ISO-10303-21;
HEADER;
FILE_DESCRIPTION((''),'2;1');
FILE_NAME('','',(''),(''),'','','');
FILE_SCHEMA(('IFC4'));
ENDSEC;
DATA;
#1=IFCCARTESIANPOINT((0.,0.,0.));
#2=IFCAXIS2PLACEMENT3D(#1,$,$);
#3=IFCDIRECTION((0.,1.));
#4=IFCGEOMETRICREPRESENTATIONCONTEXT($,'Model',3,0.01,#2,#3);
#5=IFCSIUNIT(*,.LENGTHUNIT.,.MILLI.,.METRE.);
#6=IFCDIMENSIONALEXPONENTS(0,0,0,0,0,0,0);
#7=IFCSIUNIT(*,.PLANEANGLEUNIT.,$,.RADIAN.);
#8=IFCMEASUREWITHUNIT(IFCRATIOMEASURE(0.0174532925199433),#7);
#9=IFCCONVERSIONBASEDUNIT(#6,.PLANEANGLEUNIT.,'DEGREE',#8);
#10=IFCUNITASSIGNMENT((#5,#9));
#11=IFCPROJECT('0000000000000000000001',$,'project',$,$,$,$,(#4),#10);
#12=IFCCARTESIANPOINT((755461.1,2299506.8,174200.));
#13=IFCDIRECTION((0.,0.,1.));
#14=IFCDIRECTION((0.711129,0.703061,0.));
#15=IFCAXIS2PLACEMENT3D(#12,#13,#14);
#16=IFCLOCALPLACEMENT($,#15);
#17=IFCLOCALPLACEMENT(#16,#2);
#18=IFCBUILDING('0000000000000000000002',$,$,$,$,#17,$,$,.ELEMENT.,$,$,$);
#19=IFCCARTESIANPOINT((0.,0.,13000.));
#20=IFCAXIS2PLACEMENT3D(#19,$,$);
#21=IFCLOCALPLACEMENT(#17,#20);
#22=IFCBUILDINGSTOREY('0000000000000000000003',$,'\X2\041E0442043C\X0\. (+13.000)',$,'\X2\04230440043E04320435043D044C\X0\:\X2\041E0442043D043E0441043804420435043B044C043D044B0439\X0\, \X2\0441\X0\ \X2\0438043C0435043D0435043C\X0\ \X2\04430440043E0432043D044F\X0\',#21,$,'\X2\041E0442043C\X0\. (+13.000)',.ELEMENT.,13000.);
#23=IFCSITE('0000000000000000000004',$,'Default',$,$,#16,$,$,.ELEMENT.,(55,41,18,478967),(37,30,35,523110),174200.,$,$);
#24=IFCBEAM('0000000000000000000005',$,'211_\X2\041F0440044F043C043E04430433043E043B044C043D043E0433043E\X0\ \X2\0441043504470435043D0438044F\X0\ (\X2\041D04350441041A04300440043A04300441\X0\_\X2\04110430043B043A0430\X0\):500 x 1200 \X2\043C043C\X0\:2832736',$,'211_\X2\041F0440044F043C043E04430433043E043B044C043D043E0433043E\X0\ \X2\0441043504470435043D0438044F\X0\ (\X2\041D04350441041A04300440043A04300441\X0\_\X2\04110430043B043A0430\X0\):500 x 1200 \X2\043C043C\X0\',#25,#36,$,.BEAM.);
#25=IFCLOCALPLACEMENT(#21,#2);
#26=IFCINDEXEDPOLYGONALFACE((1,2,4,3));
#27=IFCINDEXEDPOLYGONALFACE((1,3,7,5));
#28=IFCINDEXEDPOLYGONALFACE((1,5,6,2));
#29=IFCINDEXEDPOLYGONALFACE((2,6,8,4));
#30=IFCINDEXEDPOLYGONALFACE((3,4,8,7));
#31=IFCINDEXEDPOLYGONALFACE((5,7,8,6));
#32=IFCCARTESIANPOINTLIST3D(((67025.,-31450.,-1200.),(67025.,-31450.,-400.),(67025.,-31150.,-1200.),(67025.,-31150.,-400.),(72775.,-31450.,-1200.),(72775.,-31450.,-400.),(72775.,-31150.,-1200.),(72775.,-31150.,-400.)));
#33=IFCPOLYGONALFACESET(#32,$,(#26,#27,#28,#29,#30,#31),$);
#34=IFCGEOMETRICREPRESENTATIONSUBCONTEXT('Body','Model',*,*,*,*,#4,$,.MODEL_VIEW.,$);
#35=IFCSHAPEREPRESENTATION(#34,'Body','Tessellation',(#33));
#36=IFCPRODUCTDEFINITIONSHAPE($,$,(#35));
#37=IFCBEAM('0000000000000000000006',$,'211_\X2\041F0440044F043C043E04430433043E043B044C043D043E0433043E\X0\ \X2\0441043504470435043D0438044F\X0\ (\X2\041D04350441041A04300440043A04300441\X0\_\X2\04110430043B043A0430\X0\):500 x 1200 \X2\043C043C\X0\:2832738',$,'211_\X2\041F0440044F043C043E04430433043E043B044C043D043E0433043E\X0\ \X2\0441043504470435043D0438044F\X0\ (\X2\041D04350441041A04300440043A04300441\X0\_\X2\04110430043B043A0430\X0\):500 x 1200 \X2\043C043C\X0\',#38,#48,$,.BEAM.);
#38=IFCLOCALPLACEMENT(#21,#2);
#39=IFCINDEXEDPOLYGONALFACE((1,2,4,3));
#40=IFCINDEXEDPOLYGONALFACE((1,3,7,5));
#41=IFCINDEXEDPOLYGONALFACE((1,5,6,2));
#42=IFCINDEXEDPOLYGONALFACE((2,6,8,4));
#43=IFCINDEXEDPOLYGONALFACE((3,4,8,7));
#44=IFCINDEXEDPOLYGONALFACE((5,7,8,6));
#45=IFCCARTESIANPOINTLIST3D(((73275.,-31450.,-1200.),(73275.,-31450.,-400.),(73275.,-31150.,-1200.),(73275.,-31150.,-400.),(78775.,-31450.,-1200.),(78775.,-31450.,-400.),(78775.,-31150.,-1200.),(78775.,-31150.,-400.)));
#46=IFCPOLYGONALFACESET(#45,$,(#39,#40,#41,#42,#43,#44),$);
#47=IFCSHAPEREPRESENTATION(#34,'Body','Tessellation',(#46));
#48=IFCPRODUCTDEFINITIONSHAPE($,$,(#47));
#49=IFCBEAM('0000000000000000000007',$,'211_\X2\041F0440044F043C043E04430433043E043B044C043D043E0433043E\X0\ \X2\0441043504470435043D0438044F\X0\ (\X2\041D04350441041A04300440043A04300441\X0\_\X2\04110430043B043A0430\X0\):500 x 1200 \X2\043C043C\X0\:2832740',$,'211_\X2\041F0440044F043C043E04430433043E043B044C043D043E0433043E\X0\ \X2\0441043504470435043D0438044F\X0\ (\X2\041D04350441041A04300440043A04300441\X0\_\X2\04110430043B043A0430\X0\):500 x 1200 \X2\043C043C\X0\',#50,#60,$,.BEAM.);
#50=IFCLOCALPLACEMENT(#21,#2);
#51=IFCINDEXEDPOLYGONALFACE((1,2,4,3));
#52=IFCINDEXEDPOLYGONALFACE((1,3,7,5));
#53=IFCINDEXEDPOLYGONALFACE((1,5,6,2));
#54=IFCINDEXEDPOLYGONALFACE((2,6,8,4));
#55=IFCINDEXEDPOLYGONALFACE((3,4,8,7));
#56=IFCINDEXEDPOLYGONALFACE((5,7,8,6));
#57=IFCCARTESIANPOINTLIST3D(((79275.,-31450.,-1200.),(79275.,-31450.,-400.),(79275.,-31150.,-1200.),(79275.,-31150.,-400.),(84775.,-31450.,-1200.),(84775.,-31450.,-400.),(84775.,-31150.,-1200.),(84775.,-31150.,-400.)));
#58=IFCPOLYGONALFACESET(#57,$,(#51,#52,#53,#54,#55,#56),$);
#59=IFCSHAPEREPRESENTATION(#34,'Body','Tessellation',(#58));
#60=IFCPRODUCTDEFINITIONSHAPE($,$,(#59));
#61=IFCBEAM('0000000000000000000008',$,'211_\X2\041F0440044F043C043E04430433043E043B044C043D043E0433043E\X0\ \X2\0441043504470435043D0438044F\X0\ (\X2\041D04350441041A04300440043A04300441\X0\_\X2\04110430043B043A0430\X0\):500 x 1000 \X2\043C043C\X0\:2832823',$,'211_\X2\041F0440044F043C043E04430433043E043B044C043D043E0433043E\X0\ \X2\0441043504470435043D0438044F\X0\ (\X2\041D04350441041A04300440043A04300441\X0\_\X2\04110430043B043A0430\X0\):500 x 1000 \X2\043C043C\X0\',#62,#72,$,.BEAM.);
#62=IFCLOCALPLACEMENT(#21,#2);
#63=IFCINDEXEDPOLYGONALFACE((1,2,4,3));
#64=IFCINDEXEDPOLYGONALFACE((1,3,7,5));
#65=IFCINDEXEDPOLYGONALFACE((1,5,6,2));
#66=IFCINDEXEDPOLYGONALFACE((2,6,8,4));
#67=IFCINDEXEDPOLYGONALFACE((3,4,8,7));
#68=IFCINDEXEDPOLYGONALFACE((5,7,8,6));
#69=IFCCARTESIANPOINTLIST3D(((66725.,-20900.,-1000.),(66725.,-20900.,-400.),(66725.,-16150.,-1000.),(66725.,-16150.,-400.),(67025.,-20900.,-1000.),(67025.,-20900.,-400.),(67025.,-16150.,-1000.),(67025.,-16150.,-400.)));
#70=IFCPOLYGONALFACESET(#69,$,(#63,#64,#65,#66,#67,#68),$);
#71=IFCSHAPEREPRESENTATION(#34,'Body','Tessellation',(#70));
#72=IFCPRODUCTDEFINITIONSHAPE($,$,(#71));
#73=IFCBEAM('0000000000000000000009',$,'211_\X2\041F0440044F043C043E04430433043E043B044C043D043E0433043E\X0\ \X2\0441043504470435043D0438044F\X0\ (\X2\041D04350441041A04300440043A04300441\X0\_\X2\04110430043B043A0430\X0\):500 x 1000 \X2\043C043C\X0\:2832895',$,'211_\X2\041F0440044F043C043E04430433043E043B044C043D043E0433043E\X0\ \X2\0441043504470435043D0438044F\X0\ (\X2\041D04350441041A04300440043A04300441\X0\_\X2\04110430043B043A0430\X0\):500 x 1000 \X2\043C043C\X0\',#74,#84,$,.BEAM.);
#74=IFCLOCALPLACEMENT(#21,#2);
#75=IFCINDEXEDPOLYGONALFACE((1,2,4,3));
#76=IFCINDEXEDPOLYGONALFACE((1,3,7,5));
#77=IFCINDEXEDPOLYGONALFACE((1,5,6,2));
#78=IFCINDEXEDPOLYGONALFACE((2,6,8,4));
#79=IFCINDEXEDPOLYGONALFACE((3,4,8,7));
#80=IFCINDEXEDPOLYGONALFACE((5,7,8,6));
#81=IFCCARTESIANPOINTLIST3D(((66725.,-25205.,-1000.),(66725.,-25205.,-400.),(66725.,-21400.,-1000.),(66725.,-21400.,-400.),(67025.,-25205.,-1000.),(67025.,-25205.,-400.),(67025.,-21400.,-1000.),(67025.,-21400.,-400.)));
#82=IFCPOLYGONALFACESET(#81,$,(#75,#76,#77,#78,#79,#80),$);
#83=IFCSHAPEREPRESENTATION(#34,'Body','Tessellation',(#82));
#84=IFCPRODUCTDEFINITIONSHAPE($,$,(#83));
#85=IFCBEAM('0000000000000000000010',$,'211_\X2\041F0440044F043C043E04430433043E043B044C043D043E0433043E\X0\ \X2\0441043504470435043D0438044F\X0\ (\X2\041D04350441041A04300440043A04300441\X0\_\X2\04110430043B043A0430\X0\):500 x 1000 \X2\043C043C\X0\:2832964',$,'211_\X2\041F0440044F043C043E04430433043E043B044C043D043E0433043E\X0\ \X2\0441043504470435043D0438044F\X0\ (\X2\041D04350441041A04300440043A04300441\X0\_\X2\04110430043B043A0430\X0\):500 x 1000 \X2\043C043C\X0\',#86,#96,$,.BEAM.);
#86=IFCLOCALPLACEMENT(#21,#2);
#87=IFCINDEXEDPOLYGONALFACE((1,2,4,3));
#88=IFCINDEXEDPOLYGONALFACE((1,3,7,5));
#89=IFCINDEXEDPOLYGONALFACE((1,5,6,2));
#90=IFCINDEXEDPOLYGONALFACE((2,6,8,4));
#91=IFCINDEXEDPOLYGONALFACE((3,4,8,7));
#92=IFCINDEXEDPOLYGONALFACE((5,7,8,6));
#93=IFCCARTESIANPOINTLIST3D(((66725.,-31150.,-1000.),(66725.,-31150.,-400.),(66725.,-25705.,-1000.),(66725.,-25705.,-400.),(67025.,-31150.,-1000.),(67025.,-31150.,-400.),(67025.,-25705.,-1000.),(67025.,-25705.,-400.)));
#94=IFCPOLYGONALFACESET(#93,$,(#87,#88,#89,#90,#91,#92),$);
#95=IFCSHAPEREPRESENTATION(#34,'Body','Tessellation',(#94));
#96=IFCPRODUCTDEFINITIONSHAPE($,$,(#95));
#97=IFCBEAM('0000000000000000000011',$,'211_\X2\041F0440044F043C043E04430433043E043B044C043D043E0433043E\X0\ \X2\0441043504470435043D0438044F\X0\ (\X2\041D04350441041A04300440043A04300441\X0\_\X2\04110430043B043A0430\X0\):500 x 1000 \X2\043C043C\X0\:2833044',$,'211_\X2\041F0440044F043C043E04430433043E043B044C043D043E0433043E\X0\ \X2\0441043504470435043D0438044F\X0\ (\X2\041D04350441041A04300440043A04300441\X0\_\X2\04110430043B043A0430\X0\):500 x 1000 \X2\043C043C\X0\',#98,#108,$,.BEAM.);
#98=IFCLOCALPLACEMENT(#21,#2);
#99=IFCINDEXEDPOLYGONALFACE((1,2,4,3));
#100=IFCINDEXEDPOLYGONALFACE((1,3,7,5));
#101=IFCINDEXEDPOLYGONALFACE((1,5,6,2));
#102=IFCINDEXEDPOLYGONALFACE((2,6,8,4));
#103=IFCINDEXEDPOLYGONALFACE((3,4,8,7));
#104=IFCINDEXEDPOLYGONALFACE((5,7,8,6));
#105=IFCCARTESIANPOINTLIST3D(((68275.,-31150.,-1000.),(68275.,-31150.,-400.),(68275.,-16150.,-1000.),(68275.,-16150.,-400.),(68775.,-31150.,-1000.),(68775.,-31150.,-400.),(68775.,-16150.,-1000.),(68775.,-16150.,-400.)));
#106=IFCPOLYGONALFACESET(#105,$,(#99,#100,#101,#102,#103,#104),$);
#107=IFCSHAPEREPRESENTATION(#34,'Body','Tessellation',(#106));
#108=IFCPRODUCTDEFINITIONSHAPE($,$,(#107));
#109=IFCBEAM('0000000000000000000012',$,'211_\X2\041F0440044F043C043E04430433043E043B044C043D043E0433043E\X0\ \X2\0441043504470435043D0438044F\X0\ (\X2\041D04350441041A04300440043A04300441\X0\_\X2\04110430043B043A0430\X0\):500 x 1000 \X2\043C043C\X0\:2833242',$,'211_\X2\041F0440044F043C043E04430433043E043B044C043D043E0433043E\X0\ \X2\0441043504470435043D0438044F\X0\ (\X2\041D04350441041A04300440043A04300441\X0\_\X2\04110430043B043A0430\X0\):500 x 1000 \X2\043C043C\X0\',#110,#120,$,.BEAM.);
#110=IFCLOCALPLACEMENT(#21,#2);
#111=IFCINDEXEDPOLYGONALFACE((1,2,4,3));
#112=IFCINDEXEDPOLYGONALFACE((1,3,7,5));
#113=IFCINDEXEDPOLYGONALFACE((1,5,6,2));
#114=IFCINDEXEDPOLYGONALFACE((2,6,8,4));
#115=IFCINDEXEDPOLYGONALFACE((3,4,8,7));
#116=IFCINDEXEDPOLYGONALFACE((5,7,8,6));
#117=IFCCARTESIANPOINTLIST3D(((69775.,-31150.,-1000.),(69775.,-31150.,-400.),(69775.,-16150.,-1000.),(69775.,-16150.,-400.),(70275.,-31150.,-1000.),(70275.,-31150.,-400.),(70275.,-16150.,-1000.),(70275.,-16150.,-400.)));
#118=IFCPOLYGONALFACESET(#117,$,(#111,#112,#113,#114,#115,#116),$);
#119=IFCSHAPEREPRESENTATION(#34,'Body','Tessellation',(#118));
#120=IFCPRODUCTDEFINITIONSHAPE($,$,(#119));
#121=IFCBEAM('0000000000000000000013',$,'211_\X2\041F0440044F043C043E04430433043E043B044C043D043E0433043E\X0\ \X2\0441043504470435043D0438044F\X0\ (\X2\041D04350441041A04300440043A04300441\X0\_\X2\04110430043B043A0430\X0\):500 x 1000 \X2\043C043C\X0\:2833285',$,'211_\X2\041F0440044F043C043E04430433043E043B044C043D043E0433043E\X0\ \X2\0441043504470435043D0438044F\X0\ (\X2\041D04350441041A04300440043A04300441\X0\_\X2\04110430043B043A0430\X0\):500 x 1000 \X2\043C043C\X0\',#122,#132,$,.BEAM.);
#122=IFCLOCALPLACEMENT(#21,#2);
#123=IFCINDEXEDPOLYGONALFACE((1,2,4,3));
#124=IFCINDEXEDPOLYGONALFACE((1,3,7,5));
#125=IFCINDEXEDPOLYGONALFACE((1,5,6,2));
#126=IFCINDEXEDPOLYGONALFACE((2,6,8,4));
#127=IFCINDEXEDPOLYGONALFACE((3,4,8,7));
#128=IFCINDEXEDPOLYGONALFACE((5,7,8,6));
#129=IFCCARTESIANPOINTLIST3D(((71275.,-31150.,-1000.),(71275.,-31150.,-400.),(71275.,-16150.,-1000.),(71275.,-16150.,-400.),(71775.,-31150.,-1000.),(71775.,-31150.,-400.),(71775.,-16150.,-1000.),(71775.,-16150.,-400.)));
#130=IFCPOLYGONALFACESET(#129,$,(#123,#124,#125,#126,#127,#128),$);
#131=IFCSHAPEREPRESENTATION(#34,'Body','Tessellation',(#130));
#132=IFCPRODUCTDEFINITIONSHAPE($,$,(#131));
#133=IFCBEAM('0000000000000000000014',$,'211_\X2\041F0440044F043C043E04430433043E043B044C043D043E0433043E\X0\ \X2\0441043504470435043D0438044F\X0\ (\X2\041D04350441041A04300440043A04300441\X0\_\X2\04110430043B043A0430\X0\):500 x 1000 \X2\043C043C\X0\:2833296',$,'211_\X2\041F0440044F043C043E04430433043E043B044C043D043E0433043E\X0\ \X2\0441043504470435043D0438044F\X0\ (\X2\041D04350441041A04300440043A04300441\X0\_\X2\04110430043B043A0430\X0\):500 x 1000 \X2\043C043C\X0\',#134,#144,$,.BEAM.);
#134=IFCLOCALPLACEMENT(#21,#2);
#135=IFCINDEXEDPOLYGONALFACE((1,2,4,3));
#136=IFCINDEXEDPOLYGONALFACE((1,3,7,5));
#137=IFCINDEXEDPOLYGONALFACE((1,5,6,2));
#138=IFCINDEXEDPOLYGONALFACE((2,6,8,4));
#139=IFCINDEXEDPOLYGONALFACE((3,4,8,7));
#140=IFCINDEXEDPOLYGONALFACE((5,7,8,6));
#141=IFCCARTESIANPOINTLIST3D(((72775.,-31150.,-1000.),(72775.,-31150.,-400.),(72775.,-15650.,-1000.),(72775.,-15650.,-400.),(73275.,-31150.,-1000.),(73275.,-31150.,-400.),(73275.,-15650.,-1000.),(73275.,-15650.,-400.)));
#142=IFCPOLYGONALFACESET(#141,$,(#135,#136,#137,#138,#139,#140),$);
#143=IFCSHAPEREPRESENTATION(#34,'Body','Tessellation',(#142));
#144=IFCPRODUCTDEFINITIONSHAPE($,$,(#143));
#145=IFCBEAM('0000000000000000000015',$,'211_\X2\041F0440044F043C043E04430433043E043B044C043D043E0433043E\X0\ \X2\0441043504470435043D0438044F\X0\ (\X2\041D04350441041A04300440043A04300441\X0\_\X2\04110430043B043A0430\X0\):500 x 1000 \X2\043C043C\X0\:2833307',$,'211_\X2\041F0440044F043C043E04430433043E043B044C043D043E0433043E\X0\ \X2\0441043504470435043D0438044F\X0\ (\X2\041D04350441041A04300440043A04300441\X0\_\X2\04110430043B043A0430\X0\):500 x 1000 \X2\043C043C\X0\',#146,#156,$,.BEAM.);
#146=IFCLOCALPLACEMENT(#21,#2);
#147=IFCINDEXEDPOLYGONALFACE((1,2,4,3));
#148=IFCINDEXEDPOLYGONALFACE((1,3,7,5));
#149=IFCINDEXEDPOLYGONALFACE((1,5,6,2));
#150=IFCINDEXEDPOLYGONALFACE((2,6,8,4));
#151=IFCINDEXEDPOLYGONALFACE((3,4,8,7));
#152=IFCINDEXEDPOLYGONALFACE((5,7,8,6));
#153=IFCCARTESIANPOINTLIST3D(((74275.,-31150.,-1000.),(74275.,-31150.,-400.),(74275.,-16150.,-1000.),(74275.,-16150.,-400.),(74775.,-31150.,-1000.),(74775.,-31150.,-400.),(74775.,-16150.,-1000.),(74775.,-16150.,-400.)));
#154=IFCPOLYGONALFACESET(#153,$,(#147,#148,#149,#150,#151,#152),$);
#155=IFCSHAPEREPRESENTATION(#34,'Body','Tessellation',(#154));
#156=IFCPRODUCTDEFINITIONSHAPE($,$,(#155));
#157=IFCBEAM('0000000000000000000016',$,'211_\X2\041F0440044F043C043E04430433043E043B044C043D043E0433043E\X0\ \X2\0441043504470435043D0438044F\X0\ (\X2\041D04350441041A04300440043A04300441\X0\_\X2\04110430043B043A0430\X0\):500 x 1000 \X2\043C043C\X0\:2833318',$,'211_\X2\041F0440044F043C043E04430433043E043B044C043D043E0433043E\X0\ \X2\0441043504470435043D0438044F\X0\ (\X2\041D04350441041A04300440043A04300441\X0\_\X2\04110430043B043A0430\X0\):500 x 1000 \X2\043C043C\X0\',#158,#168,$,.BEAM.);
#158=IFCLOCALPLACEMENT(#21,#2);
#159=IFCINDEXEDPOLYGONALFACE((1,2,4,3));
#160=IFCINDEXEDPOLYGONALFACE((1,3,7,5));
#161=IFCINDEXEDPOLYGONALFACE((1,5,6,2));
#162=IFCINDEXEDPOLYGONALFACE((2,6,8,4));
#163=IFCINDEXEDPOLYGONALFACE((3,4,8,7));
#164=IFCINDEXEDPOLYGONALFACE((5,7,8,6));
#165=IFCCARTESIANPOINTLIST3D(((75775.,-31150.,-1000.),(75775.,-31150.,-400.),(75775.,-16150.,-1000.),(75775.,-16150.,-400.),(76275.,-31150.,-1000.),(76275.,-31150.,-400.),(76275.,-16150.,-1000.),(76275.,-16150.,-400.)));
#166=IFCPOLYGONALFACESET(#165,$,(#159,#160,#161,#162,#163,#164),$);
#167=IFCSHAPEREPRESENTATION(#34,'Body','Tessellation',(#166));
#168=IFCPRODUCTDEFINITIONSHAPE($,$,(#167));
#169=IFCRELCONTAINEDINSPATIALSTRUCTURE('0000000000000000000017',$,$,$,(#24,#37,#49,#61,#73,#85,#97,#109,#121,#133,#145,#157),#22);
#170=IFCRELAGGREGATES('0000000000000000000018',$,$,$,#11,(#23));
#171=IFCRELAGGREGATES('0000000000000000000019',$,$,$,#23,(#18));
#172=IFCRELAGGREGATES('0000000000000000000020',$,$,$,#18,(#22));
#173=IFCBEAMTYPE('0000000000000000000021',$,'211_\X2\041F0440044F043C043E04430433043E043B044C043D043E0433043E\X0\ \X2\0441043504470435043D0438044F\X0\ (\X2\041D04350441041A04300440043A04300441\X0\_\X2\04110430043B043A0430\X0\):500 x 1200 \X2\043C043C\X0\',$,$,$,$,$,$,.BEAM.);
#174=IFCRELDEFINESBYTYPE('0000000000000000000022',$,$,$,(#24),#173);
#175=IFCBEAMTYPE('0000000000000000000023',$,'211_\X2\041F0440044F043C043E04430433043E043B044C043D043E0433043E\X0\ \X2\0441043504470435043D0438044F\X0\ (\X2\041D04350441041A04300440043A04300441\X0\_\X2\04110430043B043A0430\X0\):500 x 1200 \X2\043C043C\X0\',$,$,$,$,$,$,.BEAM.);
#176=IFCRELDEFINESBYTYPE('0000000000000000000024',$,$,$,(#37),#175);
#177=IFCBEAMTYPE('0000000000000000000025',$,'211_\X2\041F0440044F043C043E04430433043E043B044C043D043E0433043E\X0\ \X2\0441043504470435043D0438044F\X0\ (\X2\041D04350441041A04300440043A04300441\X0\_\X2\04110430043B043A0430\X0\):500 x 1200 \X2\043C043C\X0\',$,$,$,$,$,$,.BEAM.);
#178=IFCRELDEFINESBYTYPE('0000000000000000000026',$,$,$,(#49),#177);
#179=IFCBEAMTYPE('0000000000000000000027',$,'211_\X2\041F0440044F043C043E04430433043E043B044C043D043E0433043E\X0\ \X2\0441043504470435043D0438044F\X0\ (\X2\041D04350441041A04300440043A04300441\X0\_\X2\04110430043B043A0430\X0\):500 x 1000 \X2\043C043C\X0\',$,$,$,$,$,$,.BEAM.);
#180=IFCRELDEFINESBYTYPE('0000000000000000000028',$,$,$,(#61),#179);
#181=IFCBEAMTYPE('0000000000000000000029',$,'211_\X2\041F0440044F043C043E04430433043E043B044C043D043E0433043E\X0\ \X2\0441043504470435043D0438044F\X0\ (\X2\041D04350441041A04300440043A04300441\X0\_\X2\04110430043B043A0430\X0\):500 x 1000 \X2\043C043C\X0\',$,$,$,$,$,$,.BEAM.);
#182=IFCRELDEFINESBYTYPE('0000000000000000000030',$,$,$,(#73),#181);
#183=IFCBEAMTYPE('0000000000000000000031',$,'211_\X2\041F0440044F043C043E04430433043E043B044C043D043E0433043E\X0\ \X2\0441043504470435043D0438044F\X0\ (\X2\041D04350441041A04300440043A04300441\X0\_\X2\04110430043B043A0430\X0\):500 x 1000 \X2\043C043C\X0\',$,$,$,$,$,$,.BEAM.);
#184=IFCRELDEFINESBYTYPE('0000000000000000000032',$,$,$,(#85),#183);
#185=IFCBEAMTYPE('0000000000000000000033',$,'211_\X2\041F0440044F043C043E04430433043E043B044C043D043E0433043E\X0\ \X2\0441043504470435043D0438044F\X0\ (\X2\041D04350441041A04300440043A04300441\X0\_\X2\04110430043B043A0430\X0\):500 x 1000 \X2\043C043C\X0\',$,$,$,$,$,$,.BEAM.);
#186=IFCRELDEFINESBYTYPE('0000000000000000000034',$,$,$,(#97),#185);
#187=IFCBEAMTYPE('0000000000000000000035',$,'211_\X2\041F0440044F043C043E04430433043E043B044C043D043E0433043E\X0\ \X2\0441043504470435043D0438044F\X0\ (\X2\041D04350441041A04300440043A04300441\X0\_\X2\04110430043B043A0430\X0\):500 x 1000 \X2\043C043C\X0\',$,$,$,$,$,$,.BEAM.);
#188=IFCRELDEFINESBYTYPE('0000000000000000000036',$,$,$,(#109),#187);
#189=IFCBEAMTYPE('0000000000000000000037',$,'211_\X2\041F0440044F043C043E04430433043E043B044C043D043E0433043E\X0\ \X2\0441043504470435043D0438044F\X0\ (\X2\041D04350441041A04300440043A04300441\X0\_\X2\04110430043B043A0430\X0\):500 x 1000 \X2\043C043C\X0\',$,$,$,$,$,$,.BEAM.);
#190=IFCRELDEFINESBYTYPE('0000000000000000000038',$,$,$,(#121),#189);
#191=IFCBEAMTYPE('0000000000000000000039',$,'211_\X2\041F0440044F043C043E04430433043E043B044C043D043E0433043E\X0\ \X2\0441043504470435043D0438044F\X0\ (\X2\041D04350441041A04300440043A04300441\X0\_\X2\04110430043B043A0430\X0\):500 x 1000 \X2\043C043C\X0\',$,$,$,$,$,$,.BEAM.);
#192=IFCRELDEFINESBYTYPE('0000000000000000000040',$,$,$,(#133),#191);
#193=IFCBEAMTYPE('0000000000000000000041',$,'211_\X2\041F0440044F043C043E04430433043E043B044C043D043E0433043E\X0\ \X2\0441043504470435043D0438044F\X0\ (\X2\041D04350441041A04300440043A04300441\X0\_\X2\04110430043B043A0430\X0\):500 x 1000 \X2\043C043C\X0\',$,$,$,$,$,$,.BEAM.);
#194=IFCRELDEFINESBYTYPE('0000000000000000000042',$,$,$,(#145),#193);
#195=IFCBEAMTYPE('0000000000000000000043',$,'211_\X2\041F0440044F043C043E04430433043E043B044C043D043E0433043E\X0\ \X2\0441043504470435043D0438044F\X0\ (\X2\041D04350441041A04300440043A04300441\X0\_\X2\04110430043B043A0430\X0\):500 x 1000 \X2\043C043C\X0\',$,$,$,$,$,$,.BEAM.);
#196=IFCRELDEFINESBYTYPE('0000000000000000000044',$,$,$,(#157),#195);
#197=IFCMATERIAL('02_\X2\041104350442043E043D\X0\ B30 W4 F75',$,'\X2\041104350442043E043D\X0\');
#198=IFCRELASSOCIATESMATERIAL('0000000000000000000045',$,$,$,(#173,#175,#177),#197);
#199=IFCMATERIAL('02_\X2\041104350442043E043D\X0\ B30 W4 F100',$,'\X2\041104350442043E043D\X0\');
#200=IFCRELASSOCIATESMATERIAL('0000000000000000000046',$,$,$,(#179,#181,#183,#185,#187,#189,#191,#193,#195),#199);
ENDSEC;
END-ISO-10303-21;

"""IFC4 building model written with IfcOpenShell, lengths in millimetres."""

from ifc_helpers import new_model, entity, si_unit, converted_unit, direction, frame, origin, place, context, subcontext, project, spatial, indexed_curve, outline, extrude, source, transform, mapped, material, type_object, type_shapes, element, save


model = new_model("IFC4")

# Units and contexts
model_context = context("Model", 3, precision=0.01, world=origin(), true_north=direction((0.0, 1.0)))
body_context = subcontext(model_context, "Body", "Model", "MODEL_VIEW")
ifc_project = project(units=[si_unit("LENGTHUNIT", "METRE", prefix="MILLI"), converted_unit("PLANEANGLEUNIT", "DEGREE", entity("IfcRatioMeasure", 0.0174532925199433), si_unit("PLANEANGLEUNIT", "RADIAN"), dimensions=[0, 0, 0, 0, 0, 0, 0])], contexts=[model_context])

# Site, building, storey
site_placement = place(None, frame((755461.1, 2299506.8, 174200.0), z_axis=(0.0, 0.0, 1.0), x_axis=(0.711129, 0.703061, 0.0)))
site = spatial("IfcSite", under=ifc_project, at=site_placement, Name="Default", CompositionType="ELEMENT", RefLatitude=(55, 41, 18, 478967), RefLongitude=(37, 30, 35, 523110), RefElevation=174200.0)
building_placement = place(site_placement, origin())
building = spatial("IfcBuilding", under=site, at=building_placement, CompositionType="ELEMENT")
storey_placement = place(building_placement, frame((0.0, 0.0, 13000.0)))
storey = spatial("IfcBuildingStorey", under=building, at=storey_placement, Name="Отм. (+13.000)", ObjectType="Уровень:Относительный, с именем уровня", LongName="Отм. (+13.000)", CompositionType="ELEMENT", Elevation=13000.0)

# Beams
ifc_material_1 = material(Name="02_Бетон B30 W4 F75", Category="Бетон")
beam_type_1 = type_object("IfcBeamType", Name="211_Прямоугольного сечения (НесКаркас_Балка):500 x 1200 мм", PredefinedType="BEAM", material=ifc_material_1)
shared_shape_1 = source(origin(), body_context, "Body", "SweptSolid", [
    extrude(outline(indexed_curve([(-400.0, -150.0), (400.0, -150.0), (400.0, 150.0), (-400.0, 150.0), (-400.0, -150.0)], self_intersect=False)), frame((67025.0, -31300.0, 12200.0), z_axis=(1.0, 0.0, 0.0), x_axis=(0.0, 0.0, -1.0)), (0.0, 0.0, 1.0), 5750.0),
])
type_shapes(beam_type_1, [shared_shape_1])
beam_1_placement = place(storey_placement, frame((0.0, 0.0, -13000.0)))
element("IfcBeam", 1, at=beam_1_placement, inside=storey, type_object=beam_type_1, Name="211_Прямоугольного сечения (НесКаркас_Балка):500 x 1200 мм:2832736", ObjectType="211_Прямоугольного сечения (НесКаркас_Балка):500 x 1200 мм", PredefinedType="BEAM", context=body_context, shape_type="MappedRepresentation", body=[
    mapped(shared_shape_1, transform((0.0, 0.0, 0.0), scale=1.0)),
])
beam_type_2 = type_object("IfcBeamType", Name="211_Прямоугольного сечения (НесКаркас_Балка):500 x 1200 мм", PredefinedType="BEAM", material=ifc_material_1)
shared_shape_2 = source(origin(), body_context, "Body", "SweptSolid", [
    extrude(outline(indexed_curve([(-400.0, -150.0), (400.0, -150.0), (400.0, 150.0), (-400.0, 150.0), (-400.0, -150.0)], self_intersect=False)), frame((73275.0, -31300.0, 12200.0), z_axis=(1.0, 0.0, 0.0), x_axis=(0.0, 0.0, -1.0)), (0.0, 0.0, 1.0), 5500.0),
])
type_shapes(beam_type_2, [shared_shape_2])
beam_2_placement = place(storey_placement, frame((0.0, 0.0, -13000.0)))
element("IfcBeam", 2, at=beam_2_placement, inside=storey, type_object=beam_type_2, Name="211_Прямоугольного сечения (НесКаркас_Балка):500 x 1200 мм:2832738", ObjectType="211_Прямоугольного сечения (НесКаркас_Балка):500 x 1200 мм", PredefinedType="BEAM", context=body_context, shape_type="MappedRepresentation", body=[
    mapped(shared_shape_2, transform((0.0, 0.0, 0.0), scale=1.0)),
])
beam_type_3 = type_object("IfcBeamType", Name="211_Прямоугольного сечения (НесКаркас_Балка):500 x 1200 мм", PredefinedType="BEAM", material=ifc_material_1)
shared_shape_3 = source(origin(), body_context, "Body", "SweptSolid", [
    extrude(outline(indexed_curve([(-400.0, -150.0), (400.0, -150.0), (400.0, 150.0), (-400.0, 150.0), (-400.0, -150.0)], self_intersect=False)), frame((79275.0, -31300.0, 12200.0), z_axis=(1.0, 0.0, 0.0), x_axis=(0.0, 0.0, -1.0)), (0.0, 0.0, 1.0), 5500.0),
])
type_shapes(beam_type_3, [shared_shape_3])
beam_3_placement = place(storey_placement, frame((0.0, 0.0, -13000.0)))
element("IfcBeam", 3, at=beam_3_placement, inside=storey, type_object=beam_type_3, Name="211_Прямоугольного сечения (НесКаркас_Балка):500 x 1200 мм:2832740", ObjectType="211_Прямоугольного сечения (НесКаркас_Балка):500 x 1200 мм", PredefinedType="BEAM", context=body_context, shape_type="MappedRepresentation", body=[
    mapped(shared_shape_3, transform((0.0, 0.0, 0.0), scale=1.0)),
])
ifc_material_2 = material(Name="02_Бетон B30 W4 F100", Category="Бетон")
beam_type_4 = type_object("IfcBeamType", Name="211_Прямоугольного сечения (НесКаркас_Балка):500 x 1000 мм", PredefinedType="BEAM", material=ifc_material_2)
shared_shape_4 = source(origin(), body_context, "Body", "SweptSolid", [
    extrude(outline(indexed_curve([(-150.0, -300.0), (150.0, -300.0), (150.0, 300.0), (-150.0, 300.0), (-150.0, -300.0)], self_intersect=False)), frame((66875.0, -16150.0, 12300.0), z_axis=(0.0, -1.0, 0.0), x_axis=(-1.0, 0.0, 0.0)), (0.0, 0.0, 1.0), 4750.0),
])
type_shapes(beam_type_4, [shared_shape_4])
beam_4_placement = place(storey_placement, frame((0.0, 0.0, -13000.0)))
element("IfcBeam", 4, at=beam_4_placement, inside=storey, type_object=beam_type_4, Name="211_Прямоугольного сечения (НесКаркас_Балка):500 x 1000 мм:2832823", ObjectType="211_Прямоугольного сечения (НесКаркас_Балка):500 x 1000 мм", PredefinedType="BEAM", context=body_context, shape_type="MappedRepresentation", body=[
    mapped(shared_shape_4, transform((0.0, 0.0, 0.0), scale=1.0)),
])
beam_type_5 = type_object("IfcBeamType", Name="211_Прямоугольного сечения (НесКаркас_Балка):500 x 1000 мм", PredefinedType="BEAM", material=ifc_material_2)
shared_shape_5 = source(origin(), body_context, "Body", "SweptSolid", [
    extrude(outline(indexed_curve([(-150.0, -300.0), (150.0, -300.0), (150.0, 300.0), (-150.0, 300.0), (-150.0, -300.0)], self_intersect=False)), frame((66875.0, -21400.0, 12300.0), z_axis=(0.0, -1.0, 0.0), x_axis=(-1.0, 0.0, 0.0)), (0.0, 0.0, 1.0), 3805.0),
])
type_shapes(beam_type_5, [shared_shape_5])
beam_5_placement = place(storey_placement, frame((0.0, 0.0, -13000.0)))
element("IfcBeam", 5, at=beam_5_placement, inside=storey, type_object=beam_type_5, Name="211_Прямоугольного сечения (НесКаркас_Балка):500 x 1000 мм:2832895", ObjectType="211_Прямоугольного сечения (НесКаркас_Балка):500 x 1000 мм", PredefinedType="BEAM", context=body_context, shape_type="MappedRepresentation", body=[
    mapped(shared_shape_5, transform((0.0, 0.0, 0.0), scale=1.0)),
])
beam_type_6 = type_object("IfcBeamType", Name="211_Прямоугольного сечения (НесКаркас_Балка):500 x 1000 мм", PredefinedType="BEAM", material=ifc_material_2)
shared_shape_6 = source(origin(), body_context, "Body", "SweptSolid", [
    extrude(outline(indexed_curve([(-150.0, -300.0), (150.0, -300.0), (150.0, 300.0), (-150.0, 300.0), (-150.0, -300.0)], self_intersect=False)), frame((66875.0, -25705.0, 12300.0), z_axis=(0.0, -1.0, 0.0), x_axis=(-1.0, 0.0, 0.0)), (0.0, 0.0, 1.0), 5445.0),
])
type_shapes(beam_type_6, [shared_shape_6])
beam_6_placement = place(storey_placement, frame((0.0, 0.0, -13000.0)))
element("IfcBeam", 6, at=beam_6_placement, inside=storey, type_object=beam_type_6, Name="211_Прямоугольного сечения (НесКаркас_Балка):500 x 1000 мм:2832964", ObjectType="211_Прямоугольного сечения (НесКаркас_Балка):500 x 1000 мм", PredefinedType="BEAM", context=body_context, shape_type="MappedRepresentation", body=[
    mapped(shared_shape_6, transform((0.0, 0.0, 0.0), scale=1.0)),
])
beam_type_7 = type_object("IfcBeamType", Name="211_Прямоугольного сечения (НесКаркас_Балка):500 x 1000 мм", PredefinedType="BEAM", material=ifc_material_2)
shared_shape_7 = source(origin(), body_context, "Body", "SweptSolid", [
    extrude(outline(indexed_curve([(-250.0, -300.0), (250.0, -300.0), (250.0, 300.0), (-250.0, 300.0), (-250.0, -300.0)], self_intersect=False)), frame((68525.0, -16150.0, 12300.0), z_axis=(0.0, -1.0, 0.0), x_axis=(-1.0, 0.0, 0.0)), (0.0, 0.0, 1.0), 15000.0),
])
type_shapes(beam_type_7, [shared_shape_7])
beam_7_placement = place(storey_placement, frame((0.0, 0.0, -13000.0)))
element("IfcBeam", 7, at=beam_7_placement, inside=storey, type_object=beam_type_7, Name="211_Прямоугольного сечения (НесКаркас_Балка):500 x 1000 мм:2833044", ObjectType="211_Прямоугольного сечения (НесКаркас_Балка):500 x 1000 мм", PredefinedType="BEAM", context=body_context, shape_type="MappedRepresentation", body=[
    mapped(shared_shape_7, transform((0.0, 0.0, 0.0), scale=1.0)),
])
beam_type_8 = type_object("IfcBeamType", Name="211_Прямоугольного сечения (НесКаркас_Балка):500 x 1000 мм", PredefinedType="BEAM", material=ifc_material_2)
shared_shape_8 = source(origin(), body_context, "Body", "SweptSolid", [
    extrude(outline(indexed_curve([(-250.0, -300.0), (250.0, -300.0), (250.0, 300.0), (-250.0, 300.0), (-250.0, -300.0)], self_intersect=False)), frame((70025.0, -16150.0, 12300.0), z_axis=(0.0, -1.0, 0.0), x_axis=(-1.0, 0.0, 0.0)), (0.0, 0.0, 1.0), 15000.0),
])
type_shapes(beam_type_8, [shared_shape_8])
beam_8_placement = place(storey_placement, frame((0.0, 0.0, -13000.0)))
element("IfcBeam", 8, at=beam_8_placement, inside=storey, type_object=beam_type_8, Name="211_Прямоугольного сечения (НесКаркас_Балка):500 x 1000 мм:2833242", ObjectType="211_Прямоугольного сечения (НесКаркас_Балка):500 x 1000 мм", PredefinedType="BEAM", context=body_context, shape_type="MappedRepresentation", body=[
    mapped(shared_shape_8, transform((0.0, 0.0, 0.0), scale=1.0)),
])
beam_type_9 = type_object("IfcBeamType", Name="211_Прямоугольного сечения (НесКаркас_Балка):500 x 1000 мм", PredefinedType="BEAM", material=ifc_material_2)
shared_shape_9 = source(origin(), body_context, "Body", "SweptSolid", [
    extrude(outline(indexed_curve([(-250.0, -300.0), (250.0, -300.0), (250.0, 300.0), (-250.0, 300.0), (-250.0, -300.0)], self_intersect=False)), frame((71525.0, -16150.0, 12300.0), z_axis=(0.0, -1.0, 0.0), x_axis=(-1.0, 0.0, 0.0)), (0.0, 0.0, 1.0), 15000.0),
])
type_shapes(beam_type_9, [shared_shape_9])
beam_9_placement = place(storey_placement, frame((0.0, 0.0, -13000.0)))
element("IfcBeam", 9, at=beam_9_placement, inside=storey, type_object=beam_type_9, Name="211_Прямоугольного сечения (НесКаркас_Балка):500 x 1000 мм:2833285", ObjectType="211_Прямоугольного сечения (НесКаркас_Балка):500 x 1000 мм", PredefinedType="BEAM", context=body_context, shape_type="MappedRepresentation", body=[
    mapped(shared_shape_9, transform((0.0, 0.0, 0.0), scale=1.0)),
])
beam_type_10 = type_object("IfcBeamType", Name="211_Прямоугольного сечения (НесКаркас_Балка):500 x 1000 мм", PredefinedType="BEAM", material=ifc_material_2)
shared_shape_10 = source(origin(), body_context, "Body", "SweptSolid", [
    extrude(outline(indexed_curve([(-250.0, -300.0), (250.0, -300.0), (250.0, 300.0), (-250.0, 300.0), (-250.0, -300.0)], self_intersect=False)), frame((73025.0, -15650.0, 12300.0), z_axis=(0.0, -1.0, 0.0), x_axis=(-1.0, 0.0, 0.0)), (0.0, 0.0, 1.0), 15500.0),
])
type_shapes(beam_type_10, [shared_shape_10])
beam_10_placement = place(storey_placement, frame((0.0, 0.0, -13000.0)))
element("IfcBeam", 10, at=beam_10_placement, inside=storey, type_object=beam_type_10, Name="211_Прямоугольного сечения (НесКаркас_Балка):500 x 1000 мм:2833296", ObjectType="211_Прямоугольного сечения (НесКаркас_Балка):500 x 1000 мм", PredefinedType="BEAM", context=body_context, shape_type="MappedRepresentation", body=[
    mapped(shared_shape_10, transform((0.0, 0.0, 0.0), scale=1.0)),
])
beam_type_11 = type_object("IfcBeamType", Name="211_Прямоугольного сечения (НесКаркас_Балка):500 x 1000 мм", PredefinedType="BEAM", material=ifc_material_2)
shared_shape_11 = source(origin(), body_context, "Body", "SweptSolid", [
    extrude(outline(indexed_curve([(-250.0, -300.0), (250.0, -300.0), (250.0, 300.0), (-250.0, 300.0), (-250.0, -300.0)], self_intersect=False)), frame((74525.0, -16150.0, 12300.0), z_axis=(0.0, -1.0, 0.0), x_axis=(-1.0, 0.0, 0.0)), (0.0, 0.0, 1.0), 15000.0),
])
type_shapes(beam_type_11, [shared_shape_11])
beam_11_placement = place(storey_placement, frame((0.0, 0.0, -13000.0)))
element("IfcBeam", 11, at=beam_11_placement, inside=storey, type_object=beam_type_11, Name="211_Прямоугольного сечения (НесКаркас_Балка):500 x 1000 мм:2833307", ObjectType="211_Прямоугольного сечения (НесКаркас_Балка):500 x 1000 мм", PredefinedType="BEAM", context=body_context, shape_type="MappedRepresentation", body=[
    mapped(shared_shape_11, transform((0.0, 0.0, 0.0), scale=1.0)),
])
beam_type_12 = type_object("IfcBeamType", Name="211_Прямоугольного сечения (НесКаркас_Балка):500 x 1000 мм", PredefinedType="BEAM", material=ifc_material_2)
shared_shape_12 = source(origin(), body_context, "Body", "SweptSolid", [
    extrude(outline(indexed_curve([(-250.0, -300.0), (250.0, -300.0), (250.0, 300.0), (-250.0, 300.0), (-250.0, -300.0)], self_intersect=False)), frame((76025.0, -16150.0, 12300.0), z_axis=(0.0, -1.0, 0.0), x_axis=(-1.0, 0.0, 0.0)), (0.0, 0.0, 1.0), 15000.0),
])
type_shapes(beam_type_12, [shared_shape_12])
beam_12_placement = place(storey_placement, frame((0.0, 0.0, -13000.0)))
element("IfcBeam", 12, at=beam_12_placement, inside=storey, type_object=beam_type_12, Name="211_Прямоугольного сечения (НесКаркас_Балка):500 x 1000 мм:2833318", ObjectType="211_Прямоугольного сечения (НесКаркас_Балка):500 x 1000 мм", PredefinedType="BEAM", context=body_context, shape_type="MappedRepresentation", body=[
    mapped(shared_shape_12, transform((0.0, 0.0, 0.0), scale=1.0)),
])

save(model, "model.ifc")
